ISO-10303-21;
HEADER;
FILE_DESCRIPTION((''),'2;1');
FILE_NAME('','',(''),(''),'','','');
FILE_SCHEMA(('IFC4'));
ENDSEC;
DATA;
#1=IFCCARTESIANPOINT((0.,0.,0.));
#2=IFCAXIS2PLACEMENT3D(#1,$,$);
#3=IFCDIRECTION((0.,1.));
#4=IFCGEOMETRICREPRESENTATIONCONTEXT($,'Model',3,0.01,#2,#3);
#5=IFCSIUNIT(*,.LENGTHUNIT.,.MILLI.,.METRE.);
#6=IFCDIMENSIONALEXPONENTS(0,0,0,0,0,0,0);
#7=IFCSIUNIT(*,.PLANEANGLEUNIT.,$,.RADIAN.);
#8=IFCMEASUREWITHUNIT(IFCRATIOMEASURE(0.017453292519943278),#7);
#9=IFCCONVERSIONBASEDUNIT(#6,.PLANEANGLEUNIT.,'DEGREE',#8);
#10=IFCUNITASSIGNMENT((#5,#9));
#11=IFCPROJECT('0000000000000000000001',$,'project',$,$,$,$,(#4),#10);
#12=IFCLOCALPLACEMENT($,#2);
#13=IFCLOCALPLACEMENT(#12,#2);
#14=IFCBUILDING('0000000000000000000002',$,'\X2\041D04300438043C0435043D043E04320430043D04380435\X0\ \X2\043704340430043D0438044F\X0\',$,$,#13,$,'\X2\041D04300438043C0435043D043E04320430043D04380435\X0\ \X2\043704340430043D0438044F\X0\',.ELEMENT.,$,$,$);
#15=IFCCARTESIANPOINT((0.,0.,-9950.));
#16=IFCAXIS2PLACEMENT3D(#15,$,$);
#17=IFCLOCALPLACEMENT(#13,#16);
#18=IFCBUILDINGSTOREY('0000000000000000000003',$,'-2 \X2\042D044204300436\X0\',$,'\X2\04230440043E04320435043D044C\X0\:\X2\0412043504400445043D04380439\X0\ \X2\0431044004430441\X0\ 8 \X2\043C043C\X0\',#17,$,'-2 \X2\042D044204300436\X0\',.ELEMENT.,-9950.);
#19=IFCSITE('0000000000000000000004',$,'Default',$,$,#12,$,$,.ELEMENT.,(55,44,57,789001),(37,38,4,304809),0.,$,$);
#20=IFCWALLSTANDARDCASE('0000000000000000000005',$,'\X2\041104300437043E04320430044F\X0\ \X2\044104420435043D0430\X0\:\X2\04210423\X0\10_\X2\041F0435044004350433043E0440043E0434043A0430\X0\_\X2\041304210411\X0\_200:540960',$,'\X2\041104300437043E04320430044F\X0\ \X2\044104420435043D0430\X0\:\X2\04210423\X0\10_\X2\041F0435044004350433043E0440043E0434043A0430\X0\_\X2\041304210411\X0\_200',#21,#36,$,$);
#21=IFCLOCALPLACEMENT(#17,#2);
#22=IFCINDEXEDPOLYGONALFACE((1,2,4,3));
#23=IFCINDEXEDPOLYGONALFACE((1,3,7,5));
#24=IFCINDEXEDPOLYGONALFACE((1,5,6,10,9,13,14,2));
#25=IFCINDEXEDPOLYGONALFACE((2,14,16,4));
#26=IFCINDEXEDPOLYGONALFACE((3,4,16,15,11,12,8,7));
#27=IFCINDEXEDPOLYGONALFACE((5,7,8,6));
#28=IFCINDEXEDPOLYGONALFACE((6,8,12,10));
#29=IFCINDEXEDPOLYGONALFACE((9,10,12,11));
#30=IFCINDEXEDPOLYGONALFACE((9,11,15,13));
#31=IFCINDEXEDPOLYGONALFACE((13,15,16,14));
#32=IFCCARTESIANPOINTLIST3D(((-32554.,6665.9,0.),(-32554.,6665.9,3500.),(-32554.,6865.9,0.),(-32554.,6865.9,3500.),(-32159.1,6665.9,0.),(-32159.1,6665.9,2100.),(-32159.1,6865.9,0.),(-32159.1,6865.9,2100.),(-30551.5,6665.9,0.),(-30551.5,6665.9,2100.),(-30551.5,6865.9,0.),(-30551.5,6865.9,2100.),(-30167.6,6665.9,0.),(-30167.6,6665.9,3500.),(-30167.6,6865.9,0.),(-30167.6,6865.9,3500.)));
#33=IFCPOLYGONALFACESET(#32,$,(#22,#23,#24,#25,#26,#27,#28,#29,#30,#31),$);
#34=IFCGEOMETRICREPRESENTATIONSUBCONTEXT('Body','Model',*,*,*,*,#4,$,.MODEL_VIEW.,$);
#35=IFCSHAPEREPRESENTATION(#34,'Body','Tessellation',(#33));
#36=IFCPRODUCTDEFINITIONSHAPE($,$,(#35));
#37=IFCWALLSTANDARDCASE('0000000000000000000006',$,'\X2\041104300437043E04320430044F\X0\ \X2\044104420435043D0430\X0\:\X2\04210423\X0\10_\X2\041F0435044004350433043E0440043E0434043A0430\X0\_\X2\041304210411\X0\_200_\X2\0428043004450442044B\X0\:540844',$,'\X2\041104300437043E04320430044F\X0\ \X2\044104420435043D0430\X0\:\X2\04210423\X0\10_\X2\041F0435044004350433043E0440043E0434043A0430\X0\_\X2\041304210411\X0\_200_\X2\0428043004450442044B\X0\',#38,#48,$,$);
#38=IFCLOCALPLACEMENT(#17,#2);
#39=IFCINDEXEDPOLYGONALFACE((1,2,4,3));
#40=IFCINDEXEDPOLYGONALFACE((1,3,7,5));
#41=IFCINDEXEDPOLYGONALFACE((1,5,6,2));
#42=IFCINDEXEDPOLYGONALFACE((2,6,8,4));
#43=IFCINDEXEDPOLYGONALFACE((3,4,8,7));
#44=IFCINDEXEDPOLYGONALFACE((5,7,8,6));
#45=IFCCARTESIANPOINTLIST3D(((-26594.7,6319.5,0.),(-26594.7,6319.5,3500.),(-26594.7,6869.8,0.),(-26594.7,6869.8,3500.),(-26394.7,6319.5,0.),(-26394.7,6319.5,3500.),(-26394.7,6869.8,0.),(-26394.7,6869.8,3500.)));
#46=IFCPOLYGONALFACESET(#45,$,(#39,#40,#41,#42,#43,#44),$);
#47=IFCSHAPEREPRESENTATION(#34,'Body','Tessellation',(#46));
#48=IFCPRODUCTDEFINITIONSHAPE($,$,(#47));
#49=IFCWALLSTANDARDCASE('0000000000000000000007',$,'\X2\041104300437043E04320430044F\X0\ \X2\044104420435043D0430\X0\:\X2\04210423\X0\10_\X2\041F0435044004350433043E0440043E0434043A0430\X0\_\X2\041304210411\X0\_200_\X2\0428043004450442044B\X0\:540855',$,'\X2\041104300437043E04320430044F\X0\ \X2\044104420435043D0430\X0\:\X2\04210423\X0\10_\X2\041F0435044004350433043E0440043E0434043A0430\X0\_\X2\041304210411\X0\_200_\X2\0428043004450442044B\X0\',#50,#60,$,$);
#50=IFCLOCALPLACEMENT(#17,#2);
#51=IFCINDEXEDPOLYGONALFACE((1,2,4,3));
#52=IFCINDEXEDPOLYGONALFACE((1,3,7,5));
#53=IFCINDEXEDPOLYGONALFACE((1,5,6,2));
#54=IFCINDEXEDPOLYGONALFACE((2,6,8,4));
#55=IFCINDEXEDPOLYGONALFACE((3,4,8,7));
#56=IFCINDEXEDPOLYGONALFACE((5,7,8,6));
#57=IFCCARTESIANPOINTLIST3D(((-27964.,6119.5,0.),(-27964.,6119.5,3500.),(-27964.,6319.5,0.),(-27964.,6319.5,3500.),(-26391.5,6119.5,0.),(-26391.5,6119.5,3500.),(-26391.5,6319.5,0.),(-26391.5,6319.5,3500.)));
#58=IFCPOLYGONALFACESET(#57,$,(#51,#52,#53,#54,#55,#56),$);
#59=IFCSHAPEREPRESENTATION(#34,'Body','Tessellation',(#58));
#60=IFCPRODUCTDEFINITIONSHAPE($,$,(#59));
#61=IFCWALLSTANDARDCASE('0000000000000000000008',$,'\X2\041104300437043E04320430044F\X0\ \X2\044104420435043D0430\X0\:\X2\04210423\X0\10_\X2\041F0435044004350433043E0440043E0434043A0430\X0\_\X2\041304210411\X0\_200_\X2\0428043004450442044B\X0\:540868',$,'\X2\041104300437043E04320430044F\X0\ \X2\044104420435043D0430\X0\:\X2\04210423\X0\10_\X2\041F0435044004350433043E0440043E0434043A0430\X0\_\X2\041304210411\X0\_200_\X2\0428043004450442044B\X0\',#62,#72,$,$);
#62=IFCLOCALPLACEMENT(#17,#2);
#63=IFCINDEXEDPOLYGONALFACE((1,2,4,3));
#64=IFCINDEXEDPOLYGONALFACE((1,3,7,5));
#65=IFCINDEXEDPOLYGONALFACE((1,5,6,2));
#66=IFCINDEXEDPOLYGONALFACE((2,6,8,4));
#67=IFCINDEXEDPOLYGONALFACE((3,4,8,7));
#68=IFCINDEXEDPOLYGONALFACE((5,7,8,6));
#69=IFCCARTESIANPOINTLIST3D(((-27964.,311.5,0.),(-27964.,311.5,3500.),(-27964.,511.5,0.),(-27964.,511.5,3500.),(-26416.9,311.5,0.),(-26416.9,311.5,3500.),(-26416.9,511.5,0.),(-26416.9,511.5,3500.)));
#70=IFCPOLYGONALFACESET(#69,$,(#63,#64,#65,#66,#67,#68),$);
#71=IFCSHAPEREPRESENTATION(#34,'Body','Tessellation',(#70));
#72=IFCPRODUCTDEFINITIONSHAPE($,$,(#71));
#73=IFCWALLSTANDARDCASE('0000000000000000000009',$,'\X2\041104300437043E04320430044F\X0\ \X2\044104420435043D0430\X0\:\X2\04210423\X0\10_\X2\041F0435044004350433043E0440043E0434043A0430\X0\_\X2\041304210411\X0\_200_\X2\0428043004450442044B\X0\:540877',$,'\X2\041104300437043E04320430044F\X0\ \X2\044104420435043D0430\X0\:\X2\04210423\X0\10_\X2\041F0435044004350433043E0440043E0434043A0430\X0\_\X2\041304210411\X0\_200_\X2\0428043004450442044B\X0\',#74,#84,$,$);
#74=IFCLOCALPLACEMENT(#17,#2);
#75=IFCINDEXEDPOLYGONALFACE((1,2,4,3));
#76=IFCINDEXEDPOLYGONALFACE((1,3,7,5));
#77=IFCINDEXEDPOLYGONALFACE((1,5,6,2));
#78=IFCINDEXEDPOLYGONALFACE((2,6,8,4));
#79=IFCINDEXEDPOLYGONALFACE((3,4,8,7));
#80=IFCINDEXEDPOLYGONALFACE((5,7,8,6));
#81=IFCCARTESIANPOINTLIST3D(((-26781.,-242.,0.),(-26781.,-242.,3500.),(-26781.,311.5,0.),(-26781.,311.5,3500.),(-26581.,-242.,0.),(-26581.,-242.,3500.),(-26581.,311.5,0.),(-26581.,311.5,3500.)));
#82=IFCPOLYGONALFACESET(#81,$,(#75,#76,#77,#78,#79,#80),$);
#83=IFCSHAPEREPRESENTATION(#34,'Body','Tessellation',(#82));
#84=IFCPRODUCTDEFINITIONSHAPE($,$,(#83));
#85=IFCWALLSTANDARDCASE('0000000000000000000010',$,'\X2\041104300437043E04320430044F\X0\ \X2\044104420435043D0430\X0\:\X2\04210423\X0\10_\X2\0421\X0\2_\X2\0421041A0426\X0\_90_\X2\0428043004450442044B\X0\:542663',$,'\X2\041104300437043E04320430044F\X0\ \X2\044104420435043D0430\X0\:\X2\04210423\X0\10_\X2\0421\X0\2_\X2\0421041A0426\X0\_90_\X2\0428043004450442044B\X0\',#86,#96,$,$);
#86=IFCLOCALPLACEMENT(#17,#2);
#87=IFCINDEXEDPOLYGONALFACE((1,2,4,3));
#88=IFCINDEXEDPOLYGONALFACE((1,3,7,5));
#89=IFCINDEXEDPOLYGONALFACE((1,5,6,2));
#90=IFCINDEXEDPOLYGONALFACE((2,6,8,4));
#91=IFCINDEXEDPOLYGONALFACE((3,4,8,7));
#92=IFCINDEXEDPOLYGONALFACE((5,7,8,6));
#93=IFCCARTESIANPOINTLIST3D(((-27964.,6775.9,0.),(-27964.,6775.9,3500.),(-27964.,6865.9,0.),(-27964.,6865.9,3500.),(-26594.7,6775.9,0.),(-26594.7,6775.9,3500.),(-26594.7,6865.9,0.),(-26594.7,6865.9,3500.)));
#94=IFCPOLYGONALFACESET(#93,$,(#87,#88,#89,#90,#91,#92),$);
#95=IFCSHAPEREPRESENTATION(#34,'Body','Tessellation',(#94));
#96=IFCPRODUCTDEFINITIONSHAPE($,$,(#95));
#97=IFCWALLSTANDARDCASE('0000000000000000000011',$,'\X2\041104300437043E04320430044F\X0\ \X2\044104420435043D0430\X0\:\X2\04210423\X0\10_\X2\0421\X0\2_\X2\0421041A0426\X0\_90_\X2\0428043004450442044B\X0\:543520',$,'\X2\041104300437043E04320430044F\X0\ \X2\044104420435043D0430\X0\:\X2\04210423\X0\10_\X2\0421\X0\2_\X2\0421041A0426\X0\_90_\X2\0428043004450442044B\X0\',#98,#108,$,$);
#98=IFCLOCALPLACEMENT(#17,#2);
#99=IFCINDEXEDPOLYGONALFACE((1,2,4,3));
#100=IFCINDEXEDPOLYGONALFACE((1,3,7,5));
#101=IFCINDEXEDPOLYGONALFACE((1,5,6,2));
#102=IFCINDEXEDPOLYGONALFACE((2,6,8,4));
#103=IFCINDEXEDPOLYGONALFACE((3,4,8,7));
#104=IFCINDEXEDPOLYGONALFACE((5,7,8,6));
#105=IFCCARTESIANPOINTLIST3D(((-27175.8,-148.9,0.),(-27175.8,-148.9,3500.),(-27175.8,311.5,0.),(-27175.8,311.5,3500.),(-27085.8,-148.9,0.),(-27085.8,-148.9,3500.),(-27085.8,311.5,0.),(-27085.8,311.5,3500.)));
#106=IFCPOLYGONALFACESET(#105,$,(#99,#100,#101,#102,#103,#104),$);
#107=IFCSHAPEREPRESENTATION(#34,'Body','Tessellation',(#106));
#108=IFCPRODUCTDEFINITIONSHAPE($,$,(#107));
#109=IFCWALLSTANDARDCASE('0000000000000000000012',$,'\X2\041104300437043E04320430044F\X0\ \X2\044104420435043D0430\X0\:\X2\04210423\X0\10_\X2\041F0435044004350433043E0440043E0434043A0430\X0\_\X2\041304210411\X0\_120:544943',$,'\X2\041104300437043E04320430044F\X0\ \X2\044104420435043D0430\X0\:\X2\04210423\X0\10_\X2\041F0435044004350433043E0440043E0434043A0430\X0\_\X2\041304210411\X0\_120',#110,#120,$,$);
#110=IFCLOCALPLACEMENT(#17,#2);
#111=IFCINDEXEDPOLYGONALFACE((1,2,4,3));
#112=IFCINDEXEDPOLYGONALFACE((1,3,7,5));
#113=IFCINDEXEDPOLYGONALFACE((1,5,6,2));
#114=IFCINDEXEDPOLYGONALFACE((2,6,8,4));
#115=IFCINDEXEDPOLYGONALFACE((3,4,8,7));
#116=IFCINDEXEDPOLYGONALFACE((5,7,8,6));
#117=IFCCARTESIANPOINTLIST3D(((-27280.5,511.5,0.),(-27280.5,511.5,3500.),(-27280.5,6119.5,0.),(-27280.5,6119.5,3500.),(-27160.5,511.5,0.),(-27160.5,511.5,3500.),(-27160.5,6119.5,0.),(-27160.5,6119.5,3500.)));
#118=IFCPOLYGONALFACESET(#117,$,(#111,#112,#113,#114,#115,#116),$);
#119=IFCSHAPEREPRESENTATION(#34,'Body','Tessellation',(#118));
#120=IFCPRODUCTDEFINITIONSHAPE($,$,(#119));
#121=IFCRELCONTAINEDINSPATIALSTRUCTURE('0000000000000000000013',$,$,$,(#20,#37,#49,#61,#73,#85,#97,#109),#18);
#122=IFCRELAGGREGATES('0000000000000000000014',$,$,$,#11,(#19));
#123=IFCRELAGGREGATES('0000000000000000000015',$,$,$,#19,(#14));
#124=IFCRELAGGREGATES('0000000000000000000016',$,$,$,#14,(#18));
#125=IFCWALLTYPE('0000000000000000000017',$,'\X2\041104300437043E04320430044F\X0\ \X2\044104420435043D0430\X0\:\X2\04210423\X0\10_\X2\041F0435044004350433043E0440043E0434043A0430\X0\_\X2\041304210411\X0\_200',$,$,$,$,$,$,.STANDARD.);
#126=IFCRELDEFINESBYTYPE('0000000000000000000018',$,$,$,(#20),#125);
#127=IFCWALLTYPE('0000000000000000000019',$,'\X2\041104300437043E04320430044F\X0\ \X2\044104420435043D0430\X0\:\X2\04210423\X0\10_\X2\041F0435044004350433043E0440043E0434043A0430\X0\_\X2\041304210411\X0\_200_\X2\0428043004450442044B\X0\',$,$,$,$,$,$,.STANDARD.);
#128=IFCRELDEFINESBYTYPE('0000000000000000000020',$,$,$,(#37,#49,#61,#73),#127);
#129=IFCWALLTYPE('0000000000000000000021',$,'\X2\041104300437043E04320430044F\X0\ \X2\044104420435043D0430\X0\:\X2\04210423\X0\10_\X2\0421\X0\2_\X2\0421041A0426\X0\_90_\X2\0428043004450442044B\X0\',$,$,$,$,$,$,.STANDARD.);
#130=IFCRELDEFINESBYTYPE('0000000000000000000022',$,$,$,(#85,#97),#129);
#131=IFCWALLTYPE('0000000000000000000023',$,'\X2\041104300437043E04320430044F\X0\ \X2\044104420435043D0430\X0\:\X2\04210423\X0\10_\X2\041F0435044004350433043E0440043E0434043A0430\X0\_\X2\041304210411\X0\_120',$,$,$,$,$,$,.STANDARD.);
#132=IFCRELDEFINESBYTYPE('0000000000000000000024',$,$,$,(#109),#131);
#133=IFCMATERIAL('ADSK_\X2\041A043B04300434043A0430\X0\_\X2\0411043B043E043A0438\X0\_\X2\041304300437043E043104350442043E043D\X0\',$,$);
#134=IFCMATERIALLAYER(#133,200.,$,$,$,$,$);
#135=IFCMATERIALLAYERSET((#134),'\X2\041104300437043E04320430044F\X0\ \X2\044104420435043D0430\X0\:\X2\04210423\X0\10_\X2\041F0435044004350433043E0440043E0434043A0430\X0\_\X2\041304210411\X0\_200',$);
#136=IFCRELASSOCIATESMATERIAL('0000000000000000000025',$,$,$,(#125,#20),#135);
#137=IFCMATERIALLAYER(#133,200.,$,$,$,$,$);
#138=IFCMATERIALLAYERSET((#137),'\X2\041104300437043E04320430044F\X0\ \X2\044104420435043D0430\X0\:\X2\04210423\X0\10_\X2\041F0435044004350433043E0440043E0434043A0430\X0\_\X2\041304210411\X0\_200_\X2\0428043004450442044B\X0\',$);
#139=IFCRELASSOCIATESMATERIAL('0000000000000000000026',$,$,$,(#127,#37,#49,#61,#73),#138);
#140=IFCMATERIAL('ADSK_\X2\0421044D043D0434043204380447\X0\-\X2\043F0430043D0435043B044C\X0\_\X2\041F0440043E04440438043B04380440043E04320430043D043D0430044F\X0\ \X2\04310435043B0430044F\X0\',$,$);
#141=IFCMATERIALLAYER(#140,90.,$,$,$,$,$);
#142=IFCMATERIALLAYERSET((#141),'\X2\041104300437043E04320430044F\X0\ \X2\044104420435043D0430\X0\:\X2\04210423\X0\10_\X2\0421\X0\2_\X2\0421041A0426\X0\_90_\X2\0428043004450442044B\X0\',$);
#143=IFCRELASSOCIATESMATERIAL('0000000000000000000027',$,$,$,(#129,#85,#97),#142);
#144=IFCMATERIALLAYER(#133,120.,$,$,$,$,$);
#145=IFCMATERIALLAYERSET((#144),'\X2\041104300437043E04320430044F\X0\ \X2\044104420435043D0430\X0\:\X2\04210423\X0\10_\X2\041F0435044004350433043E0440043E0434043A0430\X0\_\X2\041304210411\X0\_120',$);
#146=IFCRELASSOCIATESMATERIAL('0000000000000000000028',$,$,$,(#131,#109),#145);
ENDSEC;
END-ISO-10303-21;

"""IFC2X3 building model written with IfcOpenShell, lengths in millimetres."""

from ifc_helpers import new_model, entity, si_unit, converted_unit, direction, frame, frame_2d, origin, place, context, subcontext, project, spatial, rectangle, extrude, material, layer, layer_set, layer_usage, type_object, element, save


model = new_model("IFC2X3")

# Units and contexts
model_context = context("Model", 3, precision=0.01, world=origin(), true_north=direction((0.0, 1.0)))
body_context = subcontext(model_context, "Body", "Model", "MODEL_VIEW")
ifc_project = project(units=[si_unit("LENGTHUNIT", "METRE", prefix="MILLI"), converted_unit("PLANEANGLEUNIT", "DEGREE", entity("IfcRatioMeasure", 0.017453292519943278), si_unit("PLANEANGLEUNIT", "RADIAN"), dimensions=[0, 0, 0, 0, 0, 0, 0])], contexts=[model_context])

# Site, building, storey
site_placement = place(None, origin())
site = spatial("IfcSite", under=ifc_project, at=site_placement, Name="Default", CompositionType="ELEMENT", RefLatitude=(55, 44, 57, 789001), RefLongitude=(37, 38, 4, 304809), RefElevation=0.0)
building_placement = place(site_placement, origin())
building = spatial("IfcBuilding", under=site, at=building_placement, Name="Наименование здания", LongName="Наименование здания", CompositionType="ELEMENT")
storey_placement = place(building_placement, frame((0.0, 0.0, -9950.0)))
storey = spatial("IfcBuildingStorey", under=building, at=storey_placement, Name="-2 Этаж", ObjectType="Уровень:Верхний брус 8 мм", LongName="-2 Этаж", CompositionType="ELEMENT", Elevation=-9950.0)

# Shared definitions
ifc_material_1 = material(Name="ADSK_Сэндвич-панель_Профилированная белая")
ifc_material_2 = material(Name="ADSK_Кладка_Блоки_Газобетон")
ifc_layer_1 = layer(ifc_material_2, 200.0)
ifc_layer_set_1 = layer_set([ifc_layer_1], Name="Базовая стена:СУ10_Перегородка_ГСБ_200")
ifc_layer_usage_1 = layer_usage(ifc_layer_set_1, "AXIS2", "NEGATIVE", 100.0)
wall_type_1 = type_object("IfcWallType", Name="Базовая стена:СУ10_Перегородка_ГСБ_200", PredefinedType="STANDARD", material=ifc_layer_set_1)

# Wall, opening
wall_1_placement = place(storey_placement, frame((-30167.6, 6765.9, 0.0), z_axis=(0.0, 0.0, 1.0), x_axis=(-1.0, 0.0, 0.0)))
wall_1 = element("IfcWallStandardCase", 1, at=wall_1_placement, inside=storey, type_object=wall_type_1, material=ifc_layer_usage_1, Name="Базовая стена:СУ10_Перегородка_ГСБ_200:540960", ObjectType="Базовая стена:СУ10_Перегородка_ГСБ_200", context=body_context, shape_type="SweptSolid", body=[
    extrude(rectangle(XDim=2386.5, YDim=200.0, at=frame_2d((1193.2, 0.0), x_axis=(1.0, 0.0))), origin(), (0.0, 0.0, 1.0), 3500.0),
])
opening_1_placement = place(wall_1_placement, origin())
element("IfcOpeningElement", 2, at=opening_1_placement, cuts=wall_1, ObjectType="Opening", context=body_context, shape_type="SweptSolid", body=[
    extrude(rectangle(XDim=2100.0, YDim=1607.6, at=frame_2d((0.0, 0.0), x_axis=(1.0, 0.0))), frame((1187.8, -100.0, 1050.0), z_axis=(0.0, 1.0, 0.0), x_axis=(0.0, 0.0, -1.0)), (0.0, 0.0, 1.0), 200.0),
])

# Walls
ifc_layer_2 = layer(ifc_material_2, 200.0)
ifc_layer_set_2 = layer_set([ifc_layer_2], Name="Базовая стена:СУ10_Перегородка_ГСБ_200_Шахты")
ifc_layer_usage_2 = layer_usage(ifc_layer_set_2, "AXIS2", "NEGATIVE", 100.0)
wall_type_2 = type_object("IfcWallType", Name="Базовая стена:СУ10_Перегородка_ГСБ_200_Шахты", PredefinedType="STANDARD", material=ifc_layer_set_2)
wall_2_placement = place(storey_placement, frame((-26494.7, 6869.8, 0.0), z_axis=(0.0, 0.0, 1.0), x_axis=(0.0, -1.0, 0.0)))
element("IfcWallStandardCase", 3, at=wall_2_placement, inside=storey, type_object=wall_type_2, material=ifc_layer_usage_2, Name="Базовая стена:СУ10_Перегородка_ГСБ_200_Шахты:540844", ObjectType="Базовая стена:СУ10_Перегородка_ГСБ_200_Шахты", context=body_context, shape_type="SweptSolid", body=[
    extrude(rectangle(XDim=550.3, YDim=200.0, at=frame_2d((275.2, 0.0), x_axis=(-1.0, 0.0))), origin(), (0.0, 0.0, 1.0), 3500.0),
])
wall_3_placement = place(storey_placement, frame((-27964.0, 6219.5, 0.0)))
element("IfcWallStandardCase", 4, at=wall_3_placement, inside=storey, type_object=wall_type_2, material=ifc_layer_usage_2, Name="Базовая стена:СУ10_Перегородка_ГСБ_200_Шахты:540855", ObjectType="Базовая стена:СУ10_Перегородка_ГСБ_200_Шахты", context=body_context, shape_type="SweptSolid", body=[
    extrude(rectangle(XDim=1572.5, YDim=200.0, at=frame_2d((786.2, 0.0), x_axis=(-1.0, 0.0))), origin(), (0.0, 0.0, 1.0), 3500.0),
])
wall_4_placement = place(storey_placement, frame((-27964.0, 411.5, 0.0)))
element("IfcWallStandardCase", 5, at=wall_4_placement, inside=storey, type_object=wall_type_2, material=ifc_layer_usage_2, Name="Базовая стена:СУ10_Перегородка_ГСБ_200_Шахты:540868", ObjectType="Базовая стена:СУ10_Перегородка_ГСБ_200_Шахты", context=body_context, shape_type="SweptSolid", body=[
    extrude(rectangle(XDim=1547.1, YDim=200.0, at=frame_2d((773.5, 0.0), x_axis=(-1.0, 0.0))), origin(), (0.0, 0.0, 1.0), 3500.0),
])
wall_5_placement = place(storey_placement, frame((-26681.0, 311.5, 0.0), z_axis=(0.0, 0.0, 1.0), x_axis=(0.0, -1.0, 0.0)))
element("IfcWallStandardCase", 6, at=wall_5_placement, inside=storey, type_object=wall_type_2, material=ifc_layer_usage_2, Name="Базовая стена:СУ10_Перегородка_ГСБ_200_Шахты:540877", ObjectType="Базовая стена:СУ10_Перегородка_ГСБ_200_Шахты", context=body_context, shape_type="SweptSolid", body=[
    extrude(rectangle(XDim=553.5, YDim=200.0, at=frame_2d((276.8, 0.0), x_axis=(-1.0, 0.0))), origin(), (0.0, 0.0, 1.0), 3500.0),
])
ifc_layer_3 = layer(ifc_material_1, 90.0)
ifc_layer_set_3 = layer_set([ifc_layer_3], Name="Базовая стена:СУ10_С2_СКЦ_90_Шахты")
ifc_layer_usage_3 = layer_usage(ifc_layer_set_3, "AXIS2", "NEGATIVE", 45.0)
wall_type_3 = type_object("IfcWallType", Name="Базовая стена:СУ10_С2_СКЦ_90_Шахты", PredefinedType="STANDARD", material=ifc_layer_set_3)
wall_6_placement = place(storey_placement, frame((-26594.7, 6820.9, 0.0), z_axis=(0.0, 0.0, 1.0), x_axis=(-1.0, 0.0, 0.0)))
element("IfcWallStandardCase", 7, at=wall_6_placement, inside=storey, type_object=wall_type_3, material=ifc_layer_usage_3, Name="Базовая стена:СУ10_С2_СКЦ_90_Шахты:542663", ObjectType="Базовая стена:СУ10_С2_СКЦ_90_Шахты", context=body_context, shape_type="SweptSolid", body=[
    extrude(rectangle(XDim=1369.3, YDim=90.0, at=frame_2d((684.6, 0.0), x_axis=(-1.0, 0.0))), origin(), (0.0, 0.0, 1.0), 3500.0),
])
wall_7_placement = place(storey_placement, frame((-27130.8, -148.9, 0.0), z_axis=(0.0, 0.0, 1.0), x_axis=(0.0, 1.0, 0.0)))
element("IfcWallStandardCase", 8, at=wall_7_placement, inside=storey, type_object=wall_type_3, material=ifc_layer_usage_3, Name="Базовая стена:СУ10_С2_СКЦ_90_Шахты:543520", ObjectType="Базовая стена:СУ10_С2_СКЦ_90_Шахты", context=body_context, shape_type="SweptSolid", body=[
    extrude(rectangle(XDim=460.4, YDim=90.0, at=frame_2d((230.2, 0.0), x_axis=(-1.0, 0.0))), origin(), (0.0, 0.0, 1.0), 3500.0),
])
ifc_layer_4 = layer(ifc_material_2, 120.0)
ifc_layer_set_4 = layer_set([ifc_layer_4], Name="Базовая стена:СУ10_Перегородка_ГСБ_120")
ifc_layer_usage_4 = layer_usage(ifc_layer_set_4, "AXIS2", "NEGATIVE", 60.0)
wall_type_4 = type_object("IfcWallType", Name="Базовая стена:СУ10_Перегородка_ГСБ_120", PredefinedType="STANDARD", material=ifc_layer_set_4)
wall_8_placement = place(storey_placement, frame((-27220.5, 6119.5, 0.0), z_axis=(0.0, 0.0, 1.0), x_axis=(0.0, -1.0, 0.0)))
element("IfcWallStandardCase", 9, at=wall_8_placement, inside=storey, type_object=wall_type_4, material=ifc_layer_usage_4, Name="Базовая стена:СУ10_Перегородка_ГСБ_120:544943", ObjectType="Базовая стена:СУ10_Перегородка_ГСБ_120", context=body_context, shape_type="SweptSolid", body=[
    extrude(rectangle(XDim=5608.0, YDim=120.0, at=frame_2d((2804.0, 0.0), x_axis=(-1.0, 0.0))), origin(), (0.0, 0.0, 1.0), 3500.0),
])

save(model, "model.ifc")
